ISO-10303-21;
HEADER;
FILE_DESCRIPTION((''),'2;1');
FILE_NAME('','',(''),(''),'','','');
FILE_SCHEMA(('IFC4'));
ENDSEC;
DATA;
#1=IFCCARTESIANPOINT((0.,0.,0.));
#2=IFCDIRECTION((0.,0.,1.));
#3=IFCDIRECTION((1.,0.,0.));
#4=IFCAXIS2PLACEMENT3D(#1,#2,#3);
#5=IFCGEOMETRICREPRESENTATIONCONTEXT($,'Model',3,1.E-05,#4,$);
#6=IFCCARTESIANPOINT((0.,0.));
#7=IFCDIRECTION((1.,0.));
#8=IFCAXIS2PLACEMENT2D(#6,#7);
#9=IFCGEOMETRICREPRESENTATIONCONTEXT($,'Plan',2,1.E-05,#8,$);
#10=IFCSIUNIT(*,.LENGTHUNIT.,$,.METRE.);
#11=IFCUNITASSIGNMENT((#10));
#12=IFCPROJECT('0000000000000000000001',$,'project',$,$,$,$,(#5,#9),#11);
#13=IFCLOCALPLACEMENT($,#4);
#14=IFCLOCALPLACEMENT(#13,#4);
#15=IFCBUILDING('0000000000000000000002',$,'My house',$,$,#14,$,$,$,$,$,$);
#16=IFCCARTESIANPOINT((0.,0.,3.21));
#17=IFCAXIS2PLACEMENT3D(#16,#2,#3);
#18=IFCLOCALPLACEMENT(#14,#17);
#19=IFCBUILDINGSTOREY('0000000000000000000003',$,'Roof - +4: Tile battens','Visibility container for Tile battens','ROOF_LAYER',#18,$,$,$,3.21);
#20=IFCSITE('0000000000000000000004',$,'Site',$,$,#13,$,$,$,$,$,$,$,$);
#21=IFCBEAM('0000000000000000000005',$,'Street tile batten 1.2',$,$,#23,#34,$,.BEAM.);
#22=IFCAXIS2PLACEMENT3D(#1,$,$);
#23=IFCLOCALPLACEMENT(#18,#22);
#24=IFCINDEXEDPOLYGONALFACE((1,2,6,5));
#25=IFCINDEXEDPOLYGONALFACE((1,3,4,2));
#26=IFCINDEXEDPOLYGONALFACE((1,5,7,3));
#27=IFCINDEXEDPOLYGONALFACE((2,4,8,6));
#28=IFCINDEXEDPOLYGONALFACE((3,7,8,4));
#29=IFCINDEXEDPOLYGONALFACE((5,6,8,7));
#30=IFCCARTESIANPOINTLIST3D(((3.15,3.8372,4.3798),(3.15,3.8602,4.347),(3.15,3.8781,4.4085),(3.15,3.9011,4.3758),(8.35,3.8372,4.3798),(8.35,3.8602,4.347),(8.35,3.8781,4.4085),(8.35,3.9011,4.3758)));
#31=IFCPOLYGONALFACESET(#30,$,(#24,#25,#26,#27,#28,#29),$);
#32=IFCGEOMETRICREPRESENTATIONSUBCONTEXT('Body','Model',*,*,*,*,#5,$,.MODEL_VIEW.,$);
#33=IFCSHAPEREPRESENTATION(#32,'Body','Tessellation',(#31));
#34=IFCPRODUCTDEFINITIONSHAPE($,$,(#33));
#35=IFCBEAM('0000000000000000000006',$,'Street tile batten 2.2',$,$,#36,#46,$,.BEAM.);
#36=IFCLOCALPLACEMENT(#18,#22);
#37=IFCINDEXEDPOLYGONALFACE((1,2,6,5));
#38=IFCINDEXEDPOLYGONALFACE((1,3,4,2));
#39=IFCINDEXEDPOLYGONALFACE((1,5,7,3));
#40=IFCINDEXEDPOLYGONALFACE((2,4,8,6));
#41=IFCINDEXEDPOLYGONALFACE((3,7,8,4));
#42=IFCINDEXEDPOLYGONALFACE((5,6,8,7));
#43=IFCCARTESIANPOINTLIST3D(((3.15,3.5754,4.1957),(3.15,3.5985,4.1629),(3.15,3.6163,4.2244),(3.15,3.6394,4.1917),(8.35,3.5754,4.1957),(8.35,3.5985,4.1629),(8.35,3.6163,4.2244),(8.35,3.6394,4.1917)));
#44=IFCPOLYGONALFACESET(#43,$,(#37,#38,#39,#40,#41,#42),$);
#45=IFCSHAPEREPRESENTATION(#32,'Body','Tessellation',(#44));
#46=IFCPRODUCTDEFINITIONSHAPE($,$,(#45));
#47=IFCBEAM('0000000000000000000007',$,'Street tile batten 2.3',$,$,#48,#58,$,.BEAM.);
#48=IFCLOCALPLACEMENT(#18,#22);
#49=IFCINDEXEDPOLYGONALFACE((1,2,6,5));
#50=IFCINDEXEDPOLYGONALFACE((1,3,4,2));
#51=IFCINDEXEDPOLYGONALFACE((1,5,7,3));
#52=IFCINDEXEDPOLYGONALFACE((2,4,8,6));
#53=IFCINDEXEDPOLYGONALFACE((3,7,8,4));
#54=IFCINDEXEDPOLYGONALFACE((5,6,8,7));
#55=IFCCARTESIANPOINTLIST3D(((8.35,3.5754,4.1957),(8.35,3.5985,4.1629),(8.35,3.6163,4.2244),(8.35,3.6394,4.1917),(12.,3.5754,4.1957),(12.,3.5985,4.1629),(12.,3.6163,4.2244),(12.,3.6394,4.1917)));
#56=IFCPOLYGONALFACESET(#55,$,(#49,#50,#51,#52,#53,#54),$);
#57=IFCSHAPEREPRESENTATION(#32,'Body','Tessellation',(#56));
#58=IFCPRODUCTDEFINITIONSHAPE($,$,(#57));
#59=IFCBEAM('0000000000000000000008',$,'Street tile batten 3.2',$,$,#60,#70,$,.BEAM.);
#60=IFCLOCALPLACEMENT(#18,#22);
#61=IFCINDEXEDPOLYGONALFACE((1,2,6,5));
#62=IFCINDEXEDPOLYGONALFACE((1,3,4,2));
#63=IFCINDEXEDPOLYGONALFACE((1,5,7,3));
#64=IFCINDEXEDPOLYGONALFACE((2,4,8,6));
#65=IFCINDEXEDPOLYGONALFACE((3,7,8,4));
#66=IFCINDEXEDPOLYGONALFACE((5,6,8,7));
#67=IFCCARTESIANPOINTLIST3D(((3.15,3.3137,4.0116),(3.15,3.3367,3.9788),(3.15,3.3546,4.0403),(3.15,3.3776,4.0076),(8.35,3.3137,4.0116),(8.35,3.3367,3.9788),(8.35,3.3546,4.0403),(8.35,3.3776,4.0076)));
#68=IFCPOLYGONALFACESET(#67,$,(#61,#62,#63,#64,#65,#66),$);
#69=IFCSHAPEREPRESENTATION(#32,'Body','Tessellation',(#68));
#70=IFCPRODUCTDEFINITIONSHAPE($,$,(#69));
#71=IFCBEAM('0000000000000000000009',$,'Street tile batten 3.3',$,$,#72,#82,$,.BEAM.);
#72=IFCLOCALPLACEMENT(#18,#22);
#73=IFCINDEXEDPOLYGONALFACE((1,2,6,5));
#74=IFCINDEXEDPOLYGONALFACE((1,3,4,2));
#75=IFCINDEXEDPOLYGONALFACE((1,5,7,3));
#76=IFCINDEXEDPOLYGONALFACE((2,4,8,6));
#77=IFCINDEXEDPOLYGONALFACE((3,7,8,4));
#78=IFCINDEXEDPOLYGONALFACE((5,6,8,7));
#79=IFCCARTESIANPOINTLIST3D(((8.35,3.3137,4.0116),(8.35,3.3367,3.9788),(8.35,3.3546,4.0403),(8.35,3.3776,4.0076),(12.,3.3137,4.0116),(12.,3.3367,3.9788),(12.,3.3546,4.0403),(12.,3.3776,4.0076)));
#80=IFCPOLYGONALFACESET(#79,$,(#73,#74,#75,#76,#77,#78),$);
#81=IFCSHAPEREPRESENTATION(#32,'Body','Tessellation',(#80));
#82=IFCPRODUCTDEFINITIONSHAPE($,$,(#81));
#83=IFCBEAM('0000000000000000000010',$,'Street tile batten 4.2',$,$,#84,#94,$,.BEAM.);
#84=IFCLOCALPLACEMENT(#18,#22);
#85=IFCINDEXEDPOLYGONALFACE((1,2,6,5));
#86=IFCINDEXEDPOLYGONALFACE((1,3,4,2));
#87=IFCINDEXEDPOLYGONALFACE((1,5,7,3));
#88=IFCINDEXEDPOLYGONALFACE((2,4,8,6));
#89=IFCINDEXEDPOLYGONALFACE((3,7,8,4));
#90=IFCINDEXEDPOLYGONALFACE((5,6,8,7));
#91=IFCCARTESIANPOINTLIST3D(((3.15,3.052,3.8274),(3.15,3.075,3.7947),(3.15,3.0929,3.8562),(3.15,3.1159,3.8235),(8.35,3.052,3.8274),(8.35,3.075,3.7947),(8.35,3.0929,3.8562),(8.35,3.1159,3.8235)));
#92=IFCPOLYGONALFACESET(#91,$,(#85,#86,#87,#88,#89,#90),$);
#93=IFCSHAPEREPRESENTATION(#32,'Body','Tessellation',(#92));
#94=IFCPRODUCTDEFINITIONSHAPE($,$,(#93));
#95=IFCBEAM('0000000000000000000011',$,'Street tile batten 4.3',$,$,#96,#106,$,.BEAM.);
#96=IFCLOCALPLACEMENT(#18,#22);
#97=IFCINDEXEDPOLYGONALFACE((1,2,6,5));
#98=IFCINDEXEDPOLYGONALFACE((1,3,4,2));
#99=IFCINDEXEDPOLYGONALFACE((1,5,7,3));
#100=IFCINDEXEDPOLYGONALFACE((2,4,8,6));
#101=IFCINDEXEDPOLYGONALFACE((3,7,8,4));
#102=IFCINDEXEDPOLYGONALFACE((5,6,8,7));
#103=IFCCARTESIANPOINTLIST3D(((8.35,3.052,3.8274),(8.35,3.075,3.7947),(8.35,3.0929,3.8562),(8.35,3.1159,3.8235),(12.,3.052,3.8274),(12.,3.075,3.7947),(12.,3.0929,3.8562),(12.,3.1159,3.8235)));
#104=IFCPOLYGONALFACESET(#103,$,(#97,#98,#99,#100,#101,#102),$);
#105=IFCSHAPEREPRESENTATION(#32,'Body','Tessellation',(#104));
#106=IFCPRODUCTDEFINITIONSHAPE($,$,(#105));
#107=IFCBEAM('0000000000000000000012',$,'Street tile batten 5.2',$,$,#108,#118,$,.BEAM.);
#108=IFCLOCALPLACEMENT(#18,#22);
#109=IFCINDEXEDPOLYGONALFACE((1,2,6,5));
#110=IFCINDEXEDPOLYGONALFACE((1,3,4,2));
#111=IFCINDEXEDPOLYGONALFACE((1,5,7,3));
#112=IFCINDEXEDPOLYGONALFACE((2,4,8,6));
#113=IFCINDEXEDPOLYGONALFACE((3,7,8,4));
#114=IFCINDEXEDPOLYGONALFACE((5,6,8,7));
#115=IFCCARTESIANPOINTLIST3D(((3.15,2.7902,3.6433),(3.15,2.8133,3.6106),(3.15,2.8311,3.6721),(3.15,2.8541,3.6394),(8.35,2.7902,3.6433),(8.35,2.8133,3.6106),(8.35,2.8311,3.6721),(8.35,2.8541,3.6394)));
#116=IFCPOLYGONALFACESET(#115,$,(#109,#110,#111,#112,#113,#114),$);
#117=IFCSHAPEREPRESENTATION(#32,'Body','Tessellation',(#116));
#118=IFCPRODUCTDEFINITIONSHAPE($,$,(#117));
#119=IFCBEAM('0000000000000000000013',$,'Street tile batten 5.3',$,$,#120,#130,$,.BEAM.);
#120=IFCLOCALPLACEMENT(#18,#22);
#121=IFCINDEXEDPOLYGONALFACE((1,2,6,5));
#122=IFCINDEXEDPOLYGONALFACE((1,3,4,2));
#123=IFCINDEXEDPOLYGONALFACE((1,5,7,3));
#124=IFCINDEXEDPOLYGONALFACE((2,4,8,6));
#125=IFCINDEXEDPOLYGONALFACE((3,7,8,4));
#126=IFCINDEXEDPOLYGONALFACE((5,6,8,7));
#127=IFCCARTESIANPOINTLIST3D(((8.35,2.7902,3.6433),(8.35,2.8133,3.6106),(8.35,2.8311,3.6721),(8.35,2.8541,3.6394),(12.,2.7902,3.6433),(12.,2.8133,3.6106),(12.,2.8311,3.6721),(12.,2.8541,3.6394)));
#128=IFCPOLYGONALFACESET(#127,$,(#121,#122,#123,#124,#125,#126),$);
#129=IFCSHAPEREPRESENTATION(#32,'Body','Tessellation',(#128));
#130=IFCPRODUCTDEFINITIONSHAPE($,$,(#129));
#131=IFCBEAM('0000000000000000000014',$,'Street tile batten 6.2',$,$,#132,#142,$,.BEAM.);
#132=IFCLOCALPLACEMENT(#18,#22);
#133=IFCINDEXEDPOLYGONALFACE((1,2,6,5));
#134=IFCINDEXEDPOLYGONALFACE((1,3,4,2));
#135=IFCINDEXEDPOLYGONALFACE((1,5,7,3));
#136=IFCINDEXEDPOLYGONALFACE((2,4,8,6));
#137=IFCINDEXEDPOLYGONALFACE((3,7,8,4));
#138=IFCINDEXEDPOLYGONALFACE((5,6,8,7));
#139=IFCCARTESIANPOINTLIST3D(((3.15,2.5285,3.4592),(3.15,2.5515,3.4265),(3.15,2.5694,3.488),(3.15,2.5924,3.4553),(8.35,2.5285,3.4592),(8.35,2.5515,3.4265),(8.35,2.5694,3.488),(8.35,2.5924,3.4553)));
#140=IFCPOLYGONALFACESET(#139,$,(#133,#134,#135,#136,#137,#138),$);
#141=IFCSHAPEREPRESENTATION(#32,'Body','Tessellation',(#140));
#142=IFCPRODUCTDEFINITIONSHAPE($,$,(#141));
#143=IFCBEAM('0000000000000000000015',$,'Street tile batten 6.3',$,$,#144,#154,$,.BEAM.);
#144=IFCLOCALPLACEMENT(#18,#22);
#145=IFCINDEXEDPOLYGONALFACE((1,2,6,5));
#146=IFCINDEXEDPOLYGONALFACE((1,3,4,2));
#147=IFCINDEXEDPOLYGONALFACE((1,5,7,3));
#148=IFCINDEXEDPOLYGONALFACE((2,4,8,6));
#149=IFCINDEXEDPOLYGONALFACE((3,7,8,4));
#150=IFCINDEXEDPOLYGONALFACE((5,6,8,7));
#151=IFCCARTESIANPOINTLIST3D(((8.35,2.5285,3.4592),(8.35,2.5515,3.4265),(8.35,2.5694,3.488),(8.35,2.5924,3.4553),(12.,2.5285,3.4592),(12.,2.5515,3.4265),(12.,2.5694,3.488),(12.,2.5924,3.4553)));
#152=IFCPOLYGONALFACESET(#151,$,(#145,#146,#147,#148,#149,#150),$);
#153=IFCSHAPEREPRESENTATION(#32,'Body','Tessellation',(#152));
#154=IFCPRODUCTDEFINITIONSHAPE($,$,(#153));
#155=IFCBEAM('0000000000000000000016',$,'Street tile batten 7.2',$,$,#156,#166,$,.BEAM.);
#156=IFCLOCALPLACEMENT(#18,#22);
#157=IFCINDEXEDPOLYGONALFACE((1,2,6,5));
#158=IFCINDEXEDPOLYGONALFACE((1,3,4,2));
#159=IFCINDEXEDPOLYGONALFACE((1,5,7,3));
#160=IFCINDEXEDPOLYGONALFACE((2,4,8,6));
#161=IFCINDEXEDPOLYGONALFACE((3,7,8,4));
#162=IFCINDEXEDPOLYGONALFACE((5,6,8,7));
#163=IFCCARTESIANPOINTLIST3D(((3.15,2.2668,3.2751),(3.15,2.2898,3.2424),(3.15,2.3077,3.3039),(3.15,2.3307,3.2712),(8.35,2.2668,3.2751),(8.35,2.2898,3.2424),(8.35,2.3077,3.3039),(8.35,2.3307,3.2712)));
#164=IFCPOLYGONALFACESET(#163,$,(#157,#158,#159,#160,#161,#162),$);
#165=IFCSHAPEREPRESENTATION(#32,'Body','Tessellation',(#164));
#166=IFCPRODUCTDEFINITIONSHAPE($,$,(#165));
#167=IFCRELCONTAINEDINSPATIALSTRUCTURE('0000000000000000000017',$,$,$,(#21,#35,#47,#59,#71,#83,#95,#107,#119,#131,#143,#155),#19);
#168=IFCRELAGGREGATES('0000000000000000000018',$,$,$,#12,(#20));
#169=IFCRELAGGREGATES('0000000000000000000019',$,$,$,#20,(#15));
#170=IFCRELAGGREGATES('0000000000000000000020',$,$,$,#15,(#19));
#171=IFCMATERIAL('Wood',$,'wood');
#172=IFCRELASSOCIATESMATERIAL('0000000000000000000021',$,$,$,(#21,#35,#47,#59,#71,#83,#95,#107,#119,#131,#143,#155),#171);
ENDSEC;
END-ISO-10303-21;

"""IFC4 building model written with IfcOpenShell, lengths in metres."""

from ifc_helpers import new_model, si_unit, frame, origin_with_axes, origin_2d_with_axis, place, context, subcontext, project, spatial, rectangle, extrude, clip, halfspace, material, element, save


model = new_model("IFC4")

# Units and contexts
model_context = context("Model", 3, precision=1e-05, world=origin_with_axes())
plan_context = context("Plan", 2, precision=1e-05, world=origin_2d_with_axis())
body_context = subcontext(model_context, "Body", "Model", "MODEL_VIEW")
ifc_project = project(units=[si_unit("LENGTHUNIT", "METRE")], contexts=[model_context, plan_context])

# Site, building, storey
site_placement = place(None, origin_with_axes())
site = spatial("IfcSite", under=ifc_project, at=site_placement, Name="Site")
building_placement = place(site_placement, origin_with_axes())
building = spatial("IfcBuilding", under=site, at=building_placement, Name="My house")
storey_placement = place(building_placement, frame((0.0, 0.0, 3.21), z_axis=(0.0, 0.0, 1.0), x_axis=(1.0, 0.0, 0.0)))
storey = spatial("IfcBuildingStorey", under=building, at=storey_placement, Name="Roof - +4: Tile battens", Description="Visibility container for Tile battens", ObjectType="ROOF_LAYER", Elevation=3.21)

# Beams
ifc_material = material(Name="Wood", Category="wood")
beam_1_placement = place(storey_placement, frame((3.15, 3.8691, 4.3778), z_axis=(0.0, -0.575329, 0.817922), x_axis=(1.0, 0.0, 0.0)))
element("IfcBeam", 1, at=beam_1_placement, inside=storey, material=ifc_material, Name="Street tile batten 1.2", PredefinedType="BEAM", context=body_context, shape_type="Clipping", body=[
    clip(clip(extrude(rectangle(XDim=0.05, YDim=0.04), frame((0.0, 0.0, 0.0), z_axis=(1.0, 0.0, 0.0), x_axis=(0.0, 1.0, 0.0)), (0.0, 0.0, 1.0), 5.2), halfspace(frame((-3.15, -4.2584, -6.2815), z_axis=(0.0, 0.817922, -0.575329), x_axis=(1.0, 0.0, 0.0)), False)), halfspace(frame((-3.15, -7.8573, -3.7501), z_axis=(0.0, -0.817922, 0.575329), x_axis=(-1.0, 0.0, 0.0)), False)),
])
beam_2_placement = place(storey_placement, frame((3.15, 3.6074, 4.1937), z_axis=(0.0, -0.575329, 0.817922), x_axis=(1.0, 0.0, 0.0)))
element("IfcBeam", 2, at=beam_2_placement, inside=storey, material=ifc_material, Name="Street tile batten 2.2", PredefinedType="BEAM", context=body_context, shape_type="Clipping", body=[
    clip(clip(extrude(rectangle(XDim=0.05, YDim=0.04), frame((0.0, 0.0, 0.0), z_axis=(1.0, 0.0, 0.0), x_axis=(0.0, 1.0, 0.0)), (0.0, 0.0, 1.0), 5.2), halfspace(frame((-3.15, -3.9384, -6.2815), z_axis=(0.0, 0.817922, -0.575329), x_axis=(1.0, 0.0, 0.0)), False)), halfspace(frame((-3.15, -7.5373, -3.7501), z_axis=(0.0, -0.817922, 0.575329), x_axis=(-1.0, 0.0, 0.0)), False)),
])
beam_3_placement = place(storey_placement, frame((8.35, 3.6074, 4.1937), z_axis=(0.0, -0.575329, 0.817922), x_axis=(1.0, 0.0, 0.0)))
element("IfcBeam", 3, at=beam_3_placement, inside=storey, material=ifc_material, Name="Street tile batten 2.3", PredefinedType="BEAM", context=body_context, shape_type="Clipping", body=[
    clip(clip(extrude(rectangle(XDim=0.05, YDim=0.04), frame((0.0, 0.0, 0.0), z_axis=(1.0, 0.0, 0.0), x_axis=(0.0, 1.0, 0.0)), (0.0, 0.0, 1.0), 3.65), halfspace(frame((-8.35, -3.9384, -6.2815), z_axis=(0.0, 0.817922, -0.575329), x_axis=(1.0, 0.0, 0.0)), False)), halfspace(frame((-8.35, -7.5373, -3.7501), z_axis=(0.0, -0.817922, 0.575329), x_axis=(-1.0, 0.0, 0.0)), False)),
])
beam_4_placement = place(storey_placement, frame((3.15, 3.3457, 4.0096), z_axis=(0.0, -0.575329, 0.817922), x_axis=(1.0, 0.0, 0.0)))
element("IfcBeam", 4, at=beam_4_placement, inside=storey, material=ifc_material, Name="Street tile batten 3.2", PredefinedType="BEAM", context=body_context, shape_type="Clipping", body=[
    clip(clip(extrude(rectangle(XDim=0.05, YDim=0.04), frame((0.0, 0.0, 0.0), z_axis=(1.0, 0.0, 0.0), x_axis=(0.0, 1.0, 0.0)), (0.0, 0.0, 1.0), 5.2), halfspace(frame((-3.15, -3.6184, -6.2815), z_axis=(0.0, 0.817922, -0.575329), x_axis=(1.0, 0.0, 0.0)), False)), halfspace(frame((-3.15, -7.2173, -3.7501), z_axis=(0.0, -0.817922, 0.575329), x_axis=(-1.0, 0.0, 0.0)), False)),
])
beam_5_placement = place(storey_placement, frame((8.35, 3.3457, 4.0096), z_axis=(0.0, -0.575329, 0.817922), x_axis=(1.0, 0.0, 0.0)))
element("IfcBeam", 5, at=beam_5_placement, inside=storey, material=ifc_material, Name="Street tile batten 3.3", PredefinedType="BEAM", context=body_context, shape_type="Clipping", body=[
    clip(clip(extrude(rectangle(XDim=0.05, YDim=0.04), frame((0.0, 0.0, 0.0), z_axis=(1.0, 0.0, 0.0), x_axis=(0.0, 1.0, 0.0)), (0.0, 0.0, 1.0), 3.65), halfspace(frame((-8.35, -3.6184, -6.2815), z_axis=(0.0, 0.817922, -0.575329), x_axis=(1.0, 0.0, 0.0)), False)), halfspace(frame((-8.35, -7.2173, -3.7501), z_axis=(0.0, -0.817922, 0.575329), x_axis=(-1.0, 0.0, 0.0)), False)),
])
beam_6_placement = place(storey_placement, frame((3.15, 3.0839, 3.8255), z_axis=(0.0, -0.575329, 0.817922), x_axis=(1.0, 0.0, 0.0)))
element("IfcBeam", 6, at=beam_6_placement, inside=storey, material=ifc_material, Name="Street tile batten 4.2", PredefinedType="BEAM", context=body_context, shape_type="Clipping", body=[
    clip(clip(extrude(rectangle(XDim=0.05, YDim=0.04), frame((0.0, 0.0, 0.0), z_axis=(1.0, 0.0, 0.0), x_axis=(0.0, 1.0, 0.0)), (0.0, 0.0, 1.0), 5.2), halfspace(frame((-3.15, -3.2984, -6.2815), z_axis=(0.0, 0.817922, -0.575329), x_axis=(1.0, 0.0, 0.0)), False)), halfspace(frame((-3.15, -6.8973, -3.7501), z_axis=(0.0, -0.817922, 0.575329), x_axis=(-1.0, 0.0, 0.0)), False)),
])
beam_7_placement = place(storey_placement, frame((8.35, 3.0839, 3.8255), z_axis=(0.0, -0.575329, 0.817922), x_axis=(1.0, 0.0, 0.0)))
element("IfcBeam", 7, at=beam_7_placement, inside=storey, material=ifc_material, Name="Street tile batten 4.3", PredefinedType="BEAM", context=body_context, shape_type="Clipping", body=[
    clip(clip(extrude(rectangle(XDim=0.05, YDim=0.04), frame((0.0, 0.0, 0.0), z_axis=(1.0, 0.0, 0.0), x_axis=(0.0, 1.0, 0.0)), (0.0, 0.0, 1.0), 3.65), halfspace(frame((-8.35, -3.2984, -6.2815), z_axis=(0.0, 0.817922, -0.575329), x_axis=(1.0, 0.0, 0.0)), False)), halfspace(frame((-8.35, -6.8973, -3.7501), z_axis=(0.0, -0.817922, 0.575329), x_axis=(-1.0, 0.0, 0.0)), False)),
])
beam_8_placement = place(storey_placement, frame((3.15, 2.8222, 3.6414), z_axis=(0.0, -0.575329, 0.817922), x_axis=(1.0, 0.0, 0.0)))
element("IfcBeam", 8, at=beam_8_placement, inside=storey, material=ifc_material, Name="Street tile batten 5.2", PredefinedType="BEAM", context=body_context, shape_type="Clipping", body=[
    clip(clip(extrude(rectangle(XDim=0.05, YDim=0.04), frame((0.0, 0.0, 0.0), z_axis=(1.0, 0.0, 0.0), x_axis=(0.0, 1.0, 0.0)), (0.0, 0.0, 1.0), 5.2), halfspace(frame((-3.15, -2.9784, -6.2815), z_axis=(0.0, 0.817922, -0.575329), x_axis=(1.0, 0.0, 0.0)), False)), halfspace(frame((-3.15, -6.5773, -3.7501), z_axis=(0.0, -0.817922, 0.575329), x_axis=(-1.0, 0.0, 0.0)), False)),
])
beam_9_placement = place(storey_placement, frame((8.35, 2.8222, 3.6414), z_axis=(0.0, -0.575329, 0.817922), x_axis=(1.0, 0.0, 0.0)))
element("IfcBeam", 9, at=beam_9_placement, inside=storey, material=ifc_material, Name="Street tile batten 5.3", PredefinedType="BEAM", context=body_context, shape_type="Clipping", body=[
    clip(clip(extrude(rectangle(XDim=0.05, YDim=0.04), frame((0.0, 0.0, 0.0), z_axis=(1.0, 0.0, 0.0), x_axis=(0.0, 1.0, 0.0)), (0.0, 0.0, 1.0), 3.65), halfspace(frame((-8.35, -2.9784, -6.2815), z_axis=(0.0, 0.817922, -0.575329), x_axis=(1.0, 0.0, 0.0)), False)), halfspace(frame((-8.35, -6.5773, -3.7501), z_axis=(0.0, -0.817922, 0.575329), x_axis=(-1.0, 0.0, 0.0)), False)),
])
beam_10_placement = place(storey_placement, frame((3.15, 2.5605, 3.4573), z_axis=(0.0, -0.575329, 0.817922), x_axis=(1.0, 0.0, 0.0)))
element("IfcBeam", 10, at=beam_10_placement, inside=storey, material=ifc_material, Name="Street tile batten 6.2", PredefinedType="BEAM", context=body_context, shape_type="Clipping", body=[
    clip(clip(extrude(rectangle(XDim=0.05, YDim=0.04), frame((0.0, 0.0, 0.0), z_axis=(1.0, 0.0, 0.0), x_axis=(0.0, 1.0, 0.0)), (0.0, 0.0, 1.0), 5.2), halfspace(frame((-3.15, -2.6584, -6.2815), z_axis=(0.0, 0.817922, -0.575329), x_axis=(1.0, 0.0, 0.0)), False)), halfspace(frame((-3.15, -6.2573, -3.7501), z_axis=(0.0, -0.817922, 0.575329), x_axis=(-1.0, 0.0, 0.0)), False)),
])
beam_11_placement = place(storey_placement, frame((8.35, 2.5605, 3.4573), z_axis=(0.0, -0.575329, 0.817922), x_axis=(1.0, 0.0, 0.0)))
element("IfcBeam", 11, at=beam_11_placement, inside=storey, material=ifc_material, Name="Street tile batten 6.3", PredefinedType="BEAM", context=body_context, shape_type="Clipping", body=[
    clip(clip(extrude(rectangle(XDim=0.05, YDim=0.04), frame((0.0, 0.0, 0.0), z_axis=(1.0, 0.0, 0.0), x_axis=(0.0, 1.0, 0.0)), (0.0, 0.0, 1.0), 3.65), halfspace(frame((-8.35, -2.6584, -6.2815), z_axis=(0.0, 0.817922, -0.575329), x_axis=(1.0, 0.0, 0.0)), False)), halfspace(frame((-8.35, -6.2573, -3.7501), z_axis=(0.0, -0.817922, 0.575329), x_axis=(-1.0, 0.0, 0.0)), False)),
])
beam_12_placement = place(storey_placement, frame((3.15, 2.2987, 3.2732), z_axis=(0.0, -0.575329, 0.817922), x_axis=(1.0, 0.0, 0.0)))
element("IfcBeam", 12, at=beam_12_placement, inside=storey, material=ifc_material, Name="Street tile batten 7.2", PredefinedType="BEAM", context=body_context, shape_type="Clipping", body=[
    clip(clip(extrude(rectangle(XDim=0.05, YDim=0.04), frame((0.0, 0.0, 0.0), z_axis=(1.0, 0.0, 0.0), x_axis=(0.0, 1.0, 0.0)), (0.0, 0.0, 1.0), 5.2), halfspace(frame((-3.15, -2.3384, -6.2815), z_axis=(0.0, 0.817922, -0.575329), x_axis=(1.0, 0.0, 0.0)), False)), halfspace(frame((-3.15, -5.9373, -3.7501), z_axis=(0.0, -0.817922, 0.575329), x_axis=(-1.0, 0.0, 0.0)), False)),
])

save(model, "model.ifc")
